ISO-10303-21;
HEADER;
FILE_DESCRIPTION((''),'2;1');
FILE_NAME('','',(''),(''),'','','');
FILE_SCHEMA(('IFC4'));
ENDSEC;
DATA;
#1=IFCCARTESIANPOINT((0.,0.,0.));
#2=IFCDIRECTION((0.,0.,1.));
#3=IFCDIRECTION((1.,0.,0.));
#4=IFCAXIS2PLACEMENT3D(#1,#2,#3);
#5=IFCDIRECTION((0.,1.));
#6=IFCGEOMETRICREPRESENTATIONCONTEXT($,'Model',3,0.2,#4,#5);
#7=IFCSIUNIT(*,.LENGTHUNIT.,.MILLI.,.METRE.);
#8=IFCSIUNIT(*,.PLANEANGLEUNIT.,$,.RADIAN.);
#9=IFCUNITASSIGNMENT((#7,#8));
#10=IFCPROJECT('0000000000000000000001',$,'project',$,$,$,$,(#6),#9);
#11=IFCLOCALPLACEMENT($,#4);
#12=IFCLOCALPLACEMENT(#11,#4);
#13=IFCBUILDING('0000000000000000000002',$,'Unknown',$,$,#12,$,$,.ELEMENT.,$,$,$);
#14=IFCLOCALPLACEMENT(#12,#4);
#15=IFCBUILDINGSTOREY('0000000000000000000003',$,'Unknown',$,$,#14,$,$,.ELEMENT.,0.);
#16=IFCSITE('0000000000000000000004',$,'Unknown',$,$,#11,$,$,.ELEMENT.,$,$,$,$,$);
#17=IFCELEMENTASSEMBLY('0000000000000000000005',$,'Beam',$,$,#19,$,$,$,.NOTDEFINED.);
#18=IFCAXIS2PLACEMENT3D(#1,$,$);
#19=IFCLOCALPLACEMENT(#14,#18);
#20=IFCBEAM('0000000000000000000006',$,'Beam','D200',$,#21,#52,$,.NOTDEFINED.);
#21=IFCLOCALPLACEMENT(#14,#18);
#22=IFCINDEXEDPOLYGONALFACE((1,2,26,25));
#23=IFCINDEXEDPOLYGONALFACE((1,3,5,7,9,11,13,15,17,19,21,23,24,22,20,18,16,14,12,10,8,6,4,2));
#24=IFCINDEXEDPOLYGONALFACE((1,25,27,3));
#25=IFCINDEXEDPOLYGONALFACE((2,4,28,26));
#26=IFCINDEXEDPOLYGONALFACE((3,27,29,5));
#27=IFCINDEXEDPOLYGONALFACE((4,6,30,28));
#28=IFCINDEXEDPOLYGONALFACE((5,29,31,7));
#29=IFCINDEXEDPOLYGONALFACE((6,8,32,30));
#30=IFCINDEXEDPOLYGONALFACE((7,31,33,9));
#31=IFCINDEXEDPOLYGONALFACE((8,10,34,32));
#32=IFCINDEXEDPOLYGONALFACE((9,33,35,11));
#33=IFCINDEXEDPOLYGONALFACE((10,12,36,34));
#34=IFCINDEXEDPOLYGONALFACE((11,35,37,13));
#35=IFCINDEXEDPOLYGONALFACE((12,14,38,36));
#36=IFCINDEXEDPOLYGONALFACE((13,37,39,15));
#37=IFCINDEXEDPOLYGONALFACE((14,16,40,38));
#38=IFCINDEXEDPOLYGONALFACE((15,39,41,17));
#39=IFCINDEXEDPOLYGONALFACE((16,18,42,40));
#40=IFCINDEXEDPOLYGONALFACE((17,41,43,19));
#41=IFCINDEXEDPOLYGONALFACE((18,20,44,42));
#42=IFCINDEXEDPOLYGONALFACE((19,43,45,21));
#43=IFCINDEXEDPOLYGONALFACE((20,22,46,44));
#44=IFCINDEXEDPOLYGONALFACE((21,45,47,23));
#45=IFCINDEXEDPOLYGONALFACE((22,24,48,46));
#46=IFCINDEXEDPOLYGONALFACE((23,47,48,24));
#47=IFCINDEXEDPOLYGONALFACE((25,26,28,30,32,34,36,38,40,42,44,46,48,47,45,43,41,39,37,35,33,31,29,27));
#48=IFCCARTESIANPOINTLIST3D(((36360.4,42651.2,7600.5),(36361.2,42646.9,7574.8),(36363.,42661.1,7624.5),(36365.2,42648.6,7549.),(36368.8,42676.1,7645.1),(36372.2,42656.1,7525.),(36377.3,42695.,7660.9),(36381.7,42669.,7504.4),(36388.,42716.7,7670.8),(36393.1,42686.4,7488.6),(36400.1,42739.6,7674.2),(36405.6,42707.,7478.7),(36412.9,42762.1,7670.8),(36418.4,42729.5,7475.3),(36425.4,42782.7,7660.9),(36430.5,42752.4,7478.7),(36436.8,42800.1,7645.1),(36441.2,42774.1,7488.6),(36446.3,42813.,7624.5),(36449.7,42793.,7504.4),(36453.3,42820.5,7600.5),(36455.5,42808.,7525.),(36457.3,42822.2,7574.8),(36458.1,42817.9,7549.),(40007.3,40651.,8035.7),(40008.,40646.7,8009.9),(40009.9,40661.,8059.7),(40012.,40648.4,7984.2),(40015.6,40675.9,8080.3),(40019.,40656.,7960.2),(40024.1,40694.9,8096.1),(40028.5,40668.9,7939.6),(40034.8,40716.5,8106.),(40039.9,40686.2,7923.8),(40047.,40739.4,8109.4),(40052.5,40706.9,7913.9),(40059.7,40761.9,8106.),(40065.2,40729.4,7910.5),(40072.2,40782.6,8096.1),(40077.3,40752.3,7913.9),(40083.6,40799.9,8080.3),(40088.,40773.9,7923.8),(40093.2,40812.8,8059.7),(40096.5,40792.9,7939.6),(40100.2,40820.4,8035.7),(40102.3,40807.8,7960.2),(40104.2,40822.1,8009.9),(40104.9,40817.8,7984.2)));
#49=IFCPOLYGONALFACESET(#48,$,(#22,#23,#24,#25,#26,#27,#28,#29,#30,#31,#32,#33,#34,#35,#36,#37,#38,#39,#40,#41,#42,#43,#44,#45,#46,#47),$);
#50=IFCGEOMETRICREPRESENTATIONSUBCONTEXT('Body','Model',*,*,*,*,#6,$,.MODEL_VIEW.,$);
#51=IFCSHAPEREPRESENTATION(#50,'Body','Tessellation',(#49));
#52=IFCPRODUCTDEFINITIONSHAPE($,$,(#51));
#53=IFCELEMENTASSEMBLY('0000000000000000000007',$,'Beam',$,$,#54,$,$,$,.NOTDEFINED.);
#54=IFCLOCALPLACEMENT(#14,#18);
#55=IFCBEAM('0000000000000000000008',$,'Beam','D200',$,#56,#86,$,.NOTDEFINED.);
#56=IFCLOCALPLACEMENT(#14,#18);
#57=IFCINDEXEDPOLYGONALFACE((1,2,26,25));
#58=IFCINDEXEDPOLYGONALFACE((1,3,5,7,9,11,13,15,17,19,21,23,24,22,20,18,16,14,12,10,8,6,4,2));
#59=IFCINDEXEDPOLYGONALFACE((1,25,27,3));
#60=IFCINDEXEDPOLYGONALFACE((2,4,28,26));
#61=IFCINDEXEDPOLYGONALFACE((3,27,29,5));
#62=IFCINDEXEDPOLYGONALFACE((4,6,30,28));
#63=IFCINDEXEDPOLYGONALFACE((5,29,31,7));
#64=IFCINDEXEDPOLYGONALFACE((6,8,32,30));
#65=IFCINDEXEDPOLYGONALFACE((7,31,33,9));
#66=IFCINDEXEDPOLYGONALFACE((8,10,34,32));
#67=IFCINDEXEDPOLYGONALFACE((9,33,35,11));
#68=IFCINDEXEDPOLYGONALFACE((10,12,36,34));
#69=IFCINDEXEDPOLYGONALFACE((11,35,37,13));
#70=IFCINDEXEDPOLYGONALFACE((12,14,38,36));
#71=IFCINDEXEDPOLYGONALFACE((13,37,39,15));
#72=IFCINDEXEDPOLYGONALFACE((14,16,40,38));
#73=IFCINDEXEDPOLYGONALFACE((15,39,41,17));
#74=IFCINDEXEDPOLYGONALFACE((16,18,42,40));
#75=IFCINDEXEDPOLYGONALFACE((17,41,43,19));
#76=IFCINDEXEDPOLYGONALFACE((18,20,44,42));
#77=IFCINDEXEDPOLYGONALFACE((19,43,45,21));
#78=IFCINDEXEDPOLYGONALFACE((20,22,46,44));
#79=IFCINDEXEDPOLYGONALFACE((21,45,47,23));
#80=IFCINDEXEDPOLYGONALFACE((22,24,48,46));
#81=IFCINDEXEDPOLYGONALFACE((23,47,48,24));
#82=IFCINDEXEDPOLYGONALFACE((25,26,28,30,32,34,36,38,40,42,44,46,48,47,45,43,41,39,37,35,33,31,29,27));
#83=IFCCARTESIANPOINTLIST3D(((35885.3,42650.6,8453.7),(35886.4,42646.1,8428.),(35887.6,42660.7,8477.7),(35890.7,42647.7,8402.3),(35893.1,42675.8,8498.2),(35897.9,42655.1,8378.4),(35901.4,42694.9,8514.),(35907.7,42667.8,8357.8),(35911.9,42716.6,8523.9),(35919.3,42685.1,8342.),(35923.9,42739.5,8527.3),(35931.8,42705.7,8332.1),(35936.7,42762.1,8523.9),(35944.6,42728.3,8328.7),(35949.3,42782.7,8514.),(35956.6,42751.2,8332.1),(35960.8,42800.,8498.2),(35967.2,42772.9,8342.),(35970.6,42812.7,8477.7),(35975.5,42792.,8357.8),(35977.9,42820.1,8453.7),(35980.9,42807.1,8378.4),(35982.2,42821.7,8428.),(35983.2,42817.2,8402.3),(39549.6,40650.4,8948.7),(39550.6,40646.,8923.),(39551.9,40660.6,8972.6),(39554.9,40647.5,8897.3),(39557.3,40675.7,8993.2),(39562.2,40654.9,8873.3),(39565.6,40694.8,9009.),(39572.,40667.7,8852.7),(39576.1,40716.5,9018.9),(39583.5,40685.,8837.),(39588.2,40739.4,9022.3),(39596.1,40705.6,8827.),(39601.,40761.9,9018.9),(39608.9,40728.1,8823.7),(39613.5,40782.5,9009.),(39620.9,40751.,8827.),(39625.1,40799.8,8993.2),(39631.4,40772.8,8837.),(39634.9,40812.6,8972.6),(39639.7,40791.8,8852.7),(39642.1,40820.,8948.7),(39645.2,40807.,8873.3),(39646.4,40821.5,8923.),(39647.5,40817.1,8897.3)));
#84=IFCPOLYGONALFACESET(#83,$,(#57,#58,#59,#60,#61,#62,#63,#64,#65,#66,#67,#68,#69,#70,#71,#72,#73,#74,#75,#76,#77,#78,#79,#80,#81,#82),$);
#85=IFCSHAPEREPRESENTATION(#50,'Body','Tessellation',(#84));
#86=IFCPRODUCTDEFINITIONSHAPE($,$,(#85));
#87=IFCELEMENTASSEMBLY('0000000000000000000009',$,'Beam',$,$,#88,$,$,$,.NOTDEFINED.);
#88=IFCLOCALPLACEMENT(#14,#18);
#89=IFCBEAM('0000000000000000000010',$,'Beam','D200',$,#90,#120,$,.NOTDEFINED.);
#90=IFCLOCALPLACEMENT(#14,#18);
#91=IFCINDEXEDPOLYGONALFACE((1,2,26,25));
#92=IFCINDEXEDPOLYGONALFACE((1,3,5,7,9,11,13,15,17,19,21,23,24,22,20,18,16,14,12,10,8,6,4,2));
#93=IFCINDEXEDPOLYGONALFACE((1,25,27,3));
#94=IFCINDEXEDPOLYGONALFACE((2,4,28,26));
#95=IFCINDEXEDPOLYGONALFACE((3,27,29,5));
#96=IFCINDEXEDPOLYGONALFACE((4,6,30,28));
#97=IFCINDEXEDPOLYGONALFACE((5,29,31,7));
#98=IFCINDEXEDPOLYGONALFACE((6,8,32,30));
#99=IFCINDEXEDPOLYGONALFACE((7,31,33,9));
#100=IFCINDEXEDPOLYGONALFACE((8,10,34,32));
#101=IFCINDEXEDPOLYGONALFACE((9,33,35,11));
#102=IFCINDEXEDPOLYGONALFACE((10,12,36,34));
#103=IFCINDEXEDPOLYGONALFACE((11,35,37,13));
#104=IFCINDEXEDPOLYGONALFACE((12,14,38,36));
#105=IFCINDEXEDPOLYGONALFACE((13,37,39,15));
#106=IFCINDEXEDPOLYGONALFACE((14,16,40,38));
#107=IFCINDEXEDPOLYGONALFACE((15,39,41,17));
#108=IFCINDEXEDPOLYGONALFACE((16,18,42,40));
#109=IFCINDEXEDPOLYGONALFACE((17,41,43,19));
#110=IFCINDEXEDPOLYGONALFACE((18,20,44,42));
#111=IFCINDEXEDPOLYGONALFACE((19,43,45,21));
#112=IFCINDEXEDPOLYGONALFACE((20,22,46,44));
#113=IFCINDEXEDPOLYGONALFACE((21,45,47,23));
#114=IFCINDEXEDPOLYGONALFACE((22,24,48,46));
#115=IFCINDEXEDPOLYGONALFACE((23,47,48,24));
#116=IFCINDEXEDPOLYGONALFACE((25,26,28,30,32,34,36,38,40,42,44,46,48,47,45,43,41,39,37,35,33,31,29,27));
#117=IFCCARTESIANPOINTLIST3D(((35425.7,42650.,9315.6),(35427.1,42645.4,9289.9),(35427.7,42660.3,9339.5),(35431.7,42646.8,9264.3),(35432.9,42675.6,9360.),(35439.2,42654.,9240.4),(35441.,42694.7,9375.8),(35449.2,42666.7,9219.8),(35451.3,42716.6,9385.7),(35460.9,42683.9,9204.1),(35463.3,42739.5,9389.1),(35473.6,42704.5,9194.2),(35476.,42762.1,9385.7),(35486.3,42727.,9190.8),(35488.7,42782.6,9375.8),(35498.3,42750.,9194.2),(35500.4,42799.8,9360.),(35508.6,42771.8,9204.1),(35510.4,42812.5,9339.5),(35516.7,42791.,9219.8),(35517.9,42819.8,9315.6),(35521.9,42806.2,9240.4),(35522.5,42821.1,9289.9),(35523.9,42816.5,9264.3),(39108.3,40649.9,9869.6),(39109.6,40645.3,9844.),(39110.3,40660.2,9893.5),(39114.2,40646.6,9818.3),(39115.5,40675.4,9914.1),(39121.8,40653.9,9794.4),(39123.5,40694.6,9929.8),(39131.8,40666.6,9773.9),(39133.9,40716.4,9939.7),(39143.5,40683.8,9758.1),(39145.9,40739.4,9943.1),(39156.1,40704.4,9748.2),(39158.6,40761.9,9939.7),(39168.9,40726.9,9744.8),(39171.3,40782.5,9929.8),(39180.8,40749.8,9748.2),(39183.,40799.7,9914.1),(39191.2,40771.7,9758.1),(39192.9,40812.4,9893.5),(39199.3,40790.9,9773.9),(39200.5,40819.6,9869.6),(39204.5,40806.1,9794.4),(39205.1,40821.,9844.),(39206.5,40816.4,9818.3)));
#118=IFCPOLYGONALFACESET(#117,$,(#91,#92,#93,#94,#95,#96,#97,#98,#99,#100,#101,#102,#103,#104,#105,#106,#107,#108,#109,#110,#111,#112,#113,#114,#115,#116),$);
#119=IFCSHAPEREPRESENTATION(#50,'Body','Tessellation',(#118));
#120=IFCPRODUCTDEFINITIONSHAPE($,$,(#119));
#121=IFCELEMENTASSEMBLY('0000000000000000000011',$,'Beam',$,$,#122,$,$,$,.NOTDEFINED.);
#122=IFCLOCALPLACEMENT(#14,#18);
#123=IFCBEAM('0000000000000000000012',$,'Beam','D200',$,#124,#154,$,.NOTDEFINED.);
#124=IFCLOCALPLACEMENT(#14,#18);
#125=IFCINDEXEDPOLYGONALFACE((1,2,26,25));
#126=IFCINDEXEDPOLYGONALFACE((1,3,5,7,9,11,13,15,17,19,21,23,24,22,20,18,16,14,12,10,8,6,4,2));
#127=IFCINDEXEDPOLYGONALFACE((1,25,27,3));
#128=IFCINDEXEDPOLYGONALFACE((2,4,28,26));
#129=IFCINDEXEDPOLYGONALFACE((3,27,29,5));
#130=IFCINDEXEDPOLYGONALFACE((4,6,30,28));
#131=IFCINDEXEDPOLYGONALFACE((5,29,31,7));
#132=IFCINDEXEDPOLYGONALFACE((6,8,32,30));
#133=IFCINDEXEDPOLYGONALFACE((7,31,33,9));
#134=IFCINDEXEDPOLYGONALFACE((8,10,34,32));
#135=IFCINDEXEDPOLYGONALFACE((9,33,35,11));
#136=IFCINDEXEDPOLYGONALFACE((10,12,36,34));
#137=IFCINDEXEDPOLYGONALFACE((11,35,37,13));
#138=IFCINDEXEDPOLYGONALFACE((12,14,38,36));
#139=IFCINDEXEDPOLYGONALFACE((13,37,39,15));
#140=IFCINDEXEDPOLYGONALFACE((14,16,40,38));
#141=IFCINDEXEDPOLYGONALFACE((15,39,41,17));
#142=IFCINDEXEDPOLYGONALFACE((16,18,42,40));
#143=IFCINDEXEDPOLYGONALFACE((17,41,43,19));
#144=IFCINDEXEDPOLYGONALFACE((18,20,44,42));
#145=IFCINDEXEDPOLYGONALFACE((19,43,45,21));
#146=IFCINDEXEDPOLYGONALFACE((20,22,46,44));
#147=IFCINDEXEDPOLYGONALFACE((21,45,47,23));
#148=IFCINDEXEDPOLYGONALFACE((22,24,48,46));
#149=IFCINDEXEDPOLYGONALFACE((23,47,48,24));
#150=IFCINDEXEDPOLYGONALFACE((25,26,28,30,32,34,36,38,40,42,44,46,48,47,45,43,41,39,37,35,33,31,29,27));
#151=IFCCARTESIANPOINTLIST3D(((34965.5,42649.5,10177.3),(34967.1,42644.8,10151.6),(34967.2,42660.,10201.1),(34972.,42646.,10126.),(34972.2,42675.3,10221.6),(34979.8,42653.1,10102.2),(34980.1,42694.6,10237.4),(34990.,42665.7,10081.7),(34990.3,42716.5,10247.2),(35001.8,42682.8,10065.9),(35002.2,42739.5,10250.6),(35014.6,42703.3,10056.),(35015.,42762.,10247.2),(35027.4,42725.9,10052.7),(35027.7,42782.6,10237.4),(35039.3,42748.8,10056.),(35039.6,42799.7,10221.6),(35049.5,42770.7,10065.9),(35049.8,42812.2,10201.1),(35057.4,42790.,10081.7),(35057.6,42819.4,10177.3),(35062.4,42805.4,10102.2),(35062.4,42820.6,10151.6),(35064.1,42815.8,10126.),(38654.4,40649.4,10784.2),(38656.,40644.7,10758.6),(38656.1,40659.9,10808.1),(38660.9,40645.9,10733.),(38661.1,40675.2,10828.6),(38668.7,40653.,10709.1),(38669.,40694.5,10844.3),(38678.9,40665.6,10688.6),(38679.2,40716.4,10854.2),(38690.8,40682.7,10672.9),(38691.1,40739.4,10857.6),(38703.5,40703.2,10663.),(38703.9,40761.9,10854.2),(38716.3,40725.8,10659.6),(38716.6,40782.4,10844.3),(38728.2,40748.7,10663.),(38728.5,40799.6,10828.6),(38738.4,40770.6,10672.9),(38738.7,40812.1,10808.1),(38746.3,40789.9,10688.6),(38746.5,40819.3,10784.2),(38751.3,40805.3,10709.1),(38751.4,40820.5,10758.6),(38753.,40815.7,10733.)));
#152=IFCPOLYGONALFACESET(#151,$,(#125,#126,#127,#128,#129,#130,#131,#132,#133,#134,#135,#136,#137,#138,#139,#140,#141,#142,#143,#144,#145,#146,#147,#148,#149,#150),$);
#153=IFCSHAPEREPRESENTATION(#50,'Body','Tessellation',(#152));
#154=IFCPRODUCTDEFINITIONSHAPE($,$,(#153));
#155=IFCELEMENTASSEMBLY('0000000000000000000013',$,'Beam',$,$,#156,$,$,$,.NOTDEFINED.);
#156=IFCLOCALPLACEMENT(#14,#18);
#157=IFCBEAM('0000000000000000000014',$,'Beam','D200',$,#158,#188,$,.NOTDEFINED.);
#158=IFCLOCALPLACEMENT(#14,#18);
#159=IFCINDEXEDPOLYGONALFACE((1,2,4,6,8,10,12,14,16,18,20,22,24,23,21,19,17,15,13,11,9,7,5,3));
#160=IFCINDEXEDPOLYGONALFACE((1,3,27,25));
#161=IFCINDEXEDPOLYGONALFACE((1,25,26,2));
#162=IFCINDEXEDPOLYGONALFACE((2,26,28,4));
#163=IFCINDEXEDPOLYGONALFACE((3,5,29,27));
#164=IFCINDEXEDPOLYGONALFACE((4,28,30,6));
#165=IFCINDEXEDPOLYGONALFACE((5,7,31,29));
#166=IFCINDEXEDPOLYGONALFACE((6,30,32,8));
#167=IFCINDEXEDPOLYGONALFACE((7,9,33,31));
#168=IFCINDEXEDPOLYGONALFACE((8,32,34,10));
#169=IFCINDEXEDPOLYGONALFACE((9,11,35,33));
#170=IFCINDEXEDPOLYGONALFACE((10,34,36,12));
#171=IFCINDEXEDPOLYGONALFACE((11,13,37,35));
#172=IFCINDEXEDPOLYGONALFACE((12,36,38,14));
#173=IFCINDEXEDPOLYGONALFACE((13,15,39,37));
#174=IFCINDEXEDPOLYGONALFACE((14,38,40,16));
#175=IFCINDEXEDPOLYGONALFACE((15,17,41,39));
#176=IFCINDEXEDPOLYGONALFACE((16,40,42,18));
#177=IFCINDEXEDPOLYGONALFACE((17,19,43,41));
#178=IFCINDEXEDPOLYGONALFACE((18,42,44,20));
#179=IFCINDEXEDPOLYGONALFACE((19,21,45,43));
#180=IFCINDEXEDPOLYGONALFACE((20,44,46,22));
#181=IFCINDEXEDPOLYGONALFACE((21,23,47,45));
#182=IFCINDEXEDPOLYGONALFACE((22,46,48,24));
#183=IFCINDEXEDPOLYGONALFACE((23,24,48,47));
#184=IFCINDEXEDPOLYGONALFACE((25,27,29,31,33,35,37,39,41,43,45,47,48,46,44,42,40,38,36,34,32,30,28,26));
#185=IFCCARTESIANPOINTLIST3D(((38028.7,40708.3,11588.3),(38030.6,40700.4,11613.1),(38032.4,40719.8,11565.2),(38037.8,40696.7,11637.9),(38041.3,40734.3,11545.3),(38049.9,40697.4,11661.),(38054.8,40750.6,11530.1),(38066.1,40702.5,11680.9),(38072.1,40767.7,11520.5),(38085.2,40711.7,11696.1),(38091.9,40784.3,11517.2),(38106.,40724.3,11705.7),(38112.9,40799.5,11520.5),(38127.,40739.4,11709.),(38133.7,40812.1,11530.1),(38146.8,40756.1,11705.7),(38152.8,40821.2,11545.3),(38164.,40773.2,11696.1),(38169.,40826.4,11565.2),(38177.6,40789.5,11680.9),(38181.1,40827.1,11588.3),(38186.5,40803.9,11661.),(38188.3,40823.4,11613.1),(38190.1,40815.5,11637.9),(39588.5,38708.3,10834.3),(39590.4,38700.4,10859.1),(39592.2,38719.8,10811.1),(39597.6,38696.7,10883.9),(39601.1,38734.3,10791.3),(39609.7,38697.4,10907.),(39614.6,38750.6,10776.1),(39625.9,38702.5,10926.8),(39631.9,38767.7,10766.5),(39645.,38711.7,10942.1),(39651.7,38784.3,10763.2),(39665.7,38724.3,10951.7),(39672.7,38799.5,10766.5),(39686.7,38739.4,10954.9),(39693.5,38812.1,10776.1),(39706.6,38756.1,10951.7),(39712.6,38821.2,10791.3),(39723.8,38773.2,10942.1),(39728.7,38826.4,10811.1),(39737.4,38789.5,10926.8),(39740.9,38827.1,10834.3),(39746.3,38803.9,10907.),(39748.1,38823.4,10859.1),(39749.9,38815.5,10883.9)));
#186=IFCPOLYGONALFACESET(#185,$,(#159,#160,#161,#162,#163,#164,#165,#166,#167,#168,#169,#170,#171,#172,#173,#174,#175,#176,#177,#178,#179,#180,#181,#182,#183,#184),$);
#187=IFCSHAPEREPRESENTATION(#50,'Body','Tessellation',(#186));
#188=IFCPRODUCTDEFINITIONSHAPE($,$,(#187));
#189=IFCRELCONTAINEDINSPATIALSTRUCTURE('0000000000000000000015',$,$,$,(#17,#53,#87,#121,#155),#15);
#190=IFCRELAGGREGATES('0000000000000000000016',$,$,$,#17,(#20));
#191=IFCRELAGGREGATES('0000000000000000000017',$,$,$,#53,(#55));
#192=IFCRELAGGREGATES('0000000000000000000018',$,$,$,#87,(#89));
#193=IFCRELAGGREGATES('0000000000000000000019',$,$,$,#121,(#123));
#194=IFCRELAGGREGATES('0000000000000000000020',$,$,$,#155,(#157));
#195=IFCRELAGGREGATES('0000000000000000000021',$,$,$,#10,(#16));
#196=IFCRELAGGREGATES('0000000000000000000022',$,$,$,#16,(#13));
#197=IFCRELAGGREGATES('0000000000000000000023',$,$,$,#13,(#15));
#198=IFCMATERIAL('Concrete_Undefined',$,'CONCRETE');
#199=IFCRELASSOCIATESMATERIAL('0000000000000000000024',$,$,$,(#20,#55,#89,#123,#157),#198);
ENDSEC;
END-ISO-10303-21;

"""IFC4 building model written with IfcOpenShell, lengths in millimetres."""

from ifc_helpers import new_model, si_unit, direction, frame, origin_with_axes, place, context, subcontext, project, spatial, line, indexed_curve, outline, extrude, material, element, aggregate, save


model = new_model("IFC4")

# Units and contexts
model_context = context("Model", 3, precision=0.2, world=origin_with_axes(), true_north=direction((0.0, 1.0)))
body_context = subcontext(model_context, "Body", "Model", "MODEL_VIEW")
ifc_project = project(units=[si_unit("LENGTHUNIT", "METRE", prefix="MILLI"), si_unit("PLANEANGLEUNIT", "RADIAN")], contexts=[model_context])

# Site, building, storey
site_placement = place(None, origin_with_axes())
site = spatial("IfcSite", under=ifc_project, at=site_placement, Name="Unknown", CompositionType="ELEMENT")
building_placement = place(site_placement, origin_with_axes())
building = spatial("IfcBuilding", under=site, at=building_placement, Name="Unknown", CompositionType="ELEMENT")
storey_placement = place(building_placement, origin_with_axes())
storey = spatial("IfcBuildingStorey", under=building, at=storey_placement, Name="Unknown", CompositionType="ELEMENT", Elevation=0.0)

# Element assemblies, beams
assembly_1_placement = place(storey_placement, frame((36409.3, 42734.5, 7574.8), z_axis=(-0.480884, -0.876784, 0.0), x_axis=(0.872025, -0.478273, 0.104059)))
assembly_1 = element("IfcElementAssembly", 1, at=assembly_1_placement, inside=storey, Name="Beam", PredefinedType="NOTDEFINED")
ifc_material = material(Name="Concrete_Undefined", Category="CONCRETE")
beam_1_placement = place(assembly_1_placement, origin_with_axes())
beam_1 = element("IfcBeam", 2, at=beam_1_placement, material=ifc_material, Name="Beam", Description="D200", PredefinedType="NOTDEFINED", context=body_context, shape_type="SolidModel", body=[
    extrude(outline(indexed_curve([(100.0, 0.0), (96.6, 25.9), (86.6, 50.0), (70.7, 70.7), (50.0, 86.6), (25.9, 96.6), (0.0, 100.0), (-25.9, 96.6), (-50.0, 86.6), (-70.7, 70.7), (-86.6, 50.0), (-96.6, 25.9), (-100.0, 0.0), (-96.6, -25.9), (-86.6, -50.0), (-70.7, -70.7), (-50.0, -86.6), (-25.9, -96.6), (0.0, -100.0), (25.9, -96.6), (50.0, -86.6), (70.7, -70.7), (86.6, -50.0), (96.6, -25.9)], segments=[line(1, 2, 3, 4, 5, 6, 7, 8, 9, 10, 11, 12, 13, 14, 15, 16, 17, 18, 19, 20, 21, 22, 23, 24, 1)])), frame((0.0, 0.0, 0.0), z_axis=(-1.0, 0.0, 0.0), x_axis=(0.0, 0.0, 1.0)), (0.0, 0.0, -1.0), 4182.0),
])
aggregate(assembly_1, [beam_1])
assembly_2_placement = place(storey_placement, frame((35934.3, 42733.9, 8428.0), z_axis=(-0.479119, -0.87775, 0.0), x_axis=(0.871645, -0.475787, 0.117736)))
assembly_2 = element("IfcElementAssembly", 3, at=assembly_2_placement, inside=storey, Name="Beam", PredefinedType="NOTDEFINED")
beam_2_placement = place(assembly_2_placement, origin_with_axes())
beam_2 = element("IfcBeam", 4, at=beam_2_placement, material=ifc_material, Name="Beam", Description="D200", PredefinedType="NOTDEFINED", context=body_context, shape_type="SolidModel", body=[
    extrude(outline(indexed_curve([(100.0, 0.0), (96.6, 25.9), (86.6, 50.0), (70.7, 70.7), (50.0, 86.6), (25.9, 96.6), (0.0, 100.0), (-25.9, 96.6), (-50.0, 86.6), (-70.7, 70.7), (-86.6, 50.0), (-96.6, 25.9), (-100.0, 0.0), (-96.6, -25.9), (-86.6, -50.0), (-70.7, -70.7), (-50.0, -86.6), (-25.9, -96.6), (0.0, -100.0), (25.9, -96.6), (50.0, -86.6), (70.7, -70.7), (86.6, -50.0), (96.6, -25.9)], segments=[line(1, 2, 3, 4, 5, 6, 7, 8, 9, 10, 11, 12, 13, 14, 15, 16, 17, 18, 19, 20, 21, 22, 23, 24, 1)])), frame((0.0, 0.0, 0.0), z_axis=(-1.0, 0.0, 0.0), x_axis=(0.0, 0.0, 1.0)), (0.0, 0.0, -1.0), 4203.8),
])
aggregate(assembly_2, [beam_2])
assembly_3_placement = place(storey_placement, frame((35474.8, 42733.3, 9289.9), z_axis=(-0.477278, -0.878752, 0.0), x_axis=(0.871172, -0.473162, 0.13106)))
assembly_3 = element("IfcElementAssembly", 5, at=assembly_3_placement, inside=storey, Name="Beam", PredefinedType="NOTDEFINED")
beam_3_placement = place(assembly_3_placement, origin_with_axes())
beam_3 = element("IfcBeam", 6, at=beam_3_placement, material=ifc_material, Name="Beam", Description="D200", PredefinedType="NOTDEFINED", context=body_context, shape_type="SolidModel", body=[
    extrude(outline(indexed_curve([(100.0, 0.0), (96.6, 25.9), (86.6, 50.0), (70.7, 70.7), (50.0, 86.6), (25.9, 96.6), (0.0, 100.0), (-25.9, 96.6), (-50.0, 86.6), (-70.7, 70.7), (-86.6, 50.0), (-96.6, 25.9), (-100.0, 0.0), (-96.6, -25.9), (-86.6, -50.0), (-70.7, -70.7), (-50.0, -86.6), (-25.9, -96.6), (0.0, -100.0), (25.9, -96.6), (50.0, -86.6), (70.7, -70.7), (86.6, -50.0), (96.6, -25.9)], segments=[line(1, 2, 3, 4, 5, 6, 7, 8, 9, 10, 11, 12, 13, 14, 15, 16, 17, 18, 19, 20, 21, 22, 23, 24, 1)])), frame((0.0, 0.0, 0.0), z_axis=(-1.0, 0.0, 0.0), x_axis=(0.0, 0.0, 1.0)), (0.0, 0.0, -1.0), 4227.1),
])
aggregate(assembly_3, [beam_3])
assembly_4_placement = place(storey_placement, frame((35014.8, 42732.7, 10151.6), z_axis=(-0.47664, -0.879099, 0.0), x_axis=(0.870044, -0.471731, 0.143152)))
assembly_4 = element("IfcElementAssembly", 7, at=assembly_4_placement, inside=storey, Name="Beam", PredefinedType="NOTDEFINED")
beam_4_placement = place(assembly_4_placement, origin_with_axes())
beam_4 = element("IfcBeam", 8, at=beam_4_placement, material=ifc_material, Name="Beam", Description="D200", PredefinedType="NOTDEFINED", context=body_context, shape_type="SolidModel", body=[
    extrude(outline(indexed_curve([(100.0, 0.0), (96.6, 25.9), (86.6, 50.0), (70.7, 70.7), (50.0, 86.6), (25.9, 96.6), (0.0, 100.0), (-25.9, 96.6), (-50.0, 86.6), (-70.7, 70.7), (-86.6, 50.0), (-96.6, 25.9), (-100.0, 0.0), (-96.6, -25.9), (-86.6, -50.0), (-70.7, -70.7), (-50.0, -86.6), (-25.9, -96.6), (0.0, -100.0), (25.9, -96.6), (50.0, -86.6), (70.7, -70.7), (86.6, -50.0), (96.6, -25.9)], segments=[line(1, 2, 3, 4, 5, 6, 7, 8, 9, 10, 11, 12, 13, 14, 15, 16, 17, 18, 19, 20, 21, 22, 23, 24, 1)])), frame((0.0, 0.0, 0.0), z_axis=(-1.0, 0.0, 0.0), x_axis=(0.0, 0.0, 1.0)), (0.0, 0.0, -1.0), 4239.9),
])
aggregate(assembly_4, [beam_4])
assembly_5_placement = place(storey_placement, frame((38109.4, 40761.9, 11613.1), z_axis=(-0.788543, -0.61498, 0.0), x_axis=(0.589481, -0.755848, -0.284967)))
assembly_5 = element("IfcElementAssembly", 9, at=assembly_5_placement, inside=storey, Name="Beam", PredefinedType="NOTDEFINED")
beam_5_placement = place(assembly_5_placement, origin_with_axes())
beam_5 = element("IfcBeam", 10, at=beam_5_placement, material=ifc_material, Name="Beam", Description="D200", PredefinedType="NOTDEFINED", context=body_context, shape_type="SolidModel", body=[
    extrude(outline(indexed_curve([(100.0, 0.0), (96.6, 25.9), (86.6, 50.0), (70.7, 70.7), (50.0, 86.6), (25.9, 96.6), (0.0, 100.0), (-25.9, 96.6), (-50.0, 86.6), (-70.7, 70.7), (-86.6, 50.0), (-96.6, 25.9), (-100.0, 0.0), (-96.6, -25.9), (-86.6, -50.0), (-70.7, -70.7), (-50.0, -86.6), (-25.9, -96.6), (0.0, -100.0), (25.9, -96.6), (50.0, -86.6), (70.7, -70.7), (86.6, -50.0), (96.6, -25.9)], segments=[line(1, 2, 3, 4, 5, 6, 7, 8, 9, 10, 11, 12, 13, 14, 15, 16, 17, 18, 19, 20, 21, 22, 23, 24, 1)])), frame((0.0, 0.0, 0.0), z_axis=(-1.0, 0.0, 0.0), x_axis=(0.0, 0.0, 1.0)), (0.0, 0.0, -1.0), 2646.0),
])
aggregate(assembly_5, [beam_5])

save(model, "model.ifc")
